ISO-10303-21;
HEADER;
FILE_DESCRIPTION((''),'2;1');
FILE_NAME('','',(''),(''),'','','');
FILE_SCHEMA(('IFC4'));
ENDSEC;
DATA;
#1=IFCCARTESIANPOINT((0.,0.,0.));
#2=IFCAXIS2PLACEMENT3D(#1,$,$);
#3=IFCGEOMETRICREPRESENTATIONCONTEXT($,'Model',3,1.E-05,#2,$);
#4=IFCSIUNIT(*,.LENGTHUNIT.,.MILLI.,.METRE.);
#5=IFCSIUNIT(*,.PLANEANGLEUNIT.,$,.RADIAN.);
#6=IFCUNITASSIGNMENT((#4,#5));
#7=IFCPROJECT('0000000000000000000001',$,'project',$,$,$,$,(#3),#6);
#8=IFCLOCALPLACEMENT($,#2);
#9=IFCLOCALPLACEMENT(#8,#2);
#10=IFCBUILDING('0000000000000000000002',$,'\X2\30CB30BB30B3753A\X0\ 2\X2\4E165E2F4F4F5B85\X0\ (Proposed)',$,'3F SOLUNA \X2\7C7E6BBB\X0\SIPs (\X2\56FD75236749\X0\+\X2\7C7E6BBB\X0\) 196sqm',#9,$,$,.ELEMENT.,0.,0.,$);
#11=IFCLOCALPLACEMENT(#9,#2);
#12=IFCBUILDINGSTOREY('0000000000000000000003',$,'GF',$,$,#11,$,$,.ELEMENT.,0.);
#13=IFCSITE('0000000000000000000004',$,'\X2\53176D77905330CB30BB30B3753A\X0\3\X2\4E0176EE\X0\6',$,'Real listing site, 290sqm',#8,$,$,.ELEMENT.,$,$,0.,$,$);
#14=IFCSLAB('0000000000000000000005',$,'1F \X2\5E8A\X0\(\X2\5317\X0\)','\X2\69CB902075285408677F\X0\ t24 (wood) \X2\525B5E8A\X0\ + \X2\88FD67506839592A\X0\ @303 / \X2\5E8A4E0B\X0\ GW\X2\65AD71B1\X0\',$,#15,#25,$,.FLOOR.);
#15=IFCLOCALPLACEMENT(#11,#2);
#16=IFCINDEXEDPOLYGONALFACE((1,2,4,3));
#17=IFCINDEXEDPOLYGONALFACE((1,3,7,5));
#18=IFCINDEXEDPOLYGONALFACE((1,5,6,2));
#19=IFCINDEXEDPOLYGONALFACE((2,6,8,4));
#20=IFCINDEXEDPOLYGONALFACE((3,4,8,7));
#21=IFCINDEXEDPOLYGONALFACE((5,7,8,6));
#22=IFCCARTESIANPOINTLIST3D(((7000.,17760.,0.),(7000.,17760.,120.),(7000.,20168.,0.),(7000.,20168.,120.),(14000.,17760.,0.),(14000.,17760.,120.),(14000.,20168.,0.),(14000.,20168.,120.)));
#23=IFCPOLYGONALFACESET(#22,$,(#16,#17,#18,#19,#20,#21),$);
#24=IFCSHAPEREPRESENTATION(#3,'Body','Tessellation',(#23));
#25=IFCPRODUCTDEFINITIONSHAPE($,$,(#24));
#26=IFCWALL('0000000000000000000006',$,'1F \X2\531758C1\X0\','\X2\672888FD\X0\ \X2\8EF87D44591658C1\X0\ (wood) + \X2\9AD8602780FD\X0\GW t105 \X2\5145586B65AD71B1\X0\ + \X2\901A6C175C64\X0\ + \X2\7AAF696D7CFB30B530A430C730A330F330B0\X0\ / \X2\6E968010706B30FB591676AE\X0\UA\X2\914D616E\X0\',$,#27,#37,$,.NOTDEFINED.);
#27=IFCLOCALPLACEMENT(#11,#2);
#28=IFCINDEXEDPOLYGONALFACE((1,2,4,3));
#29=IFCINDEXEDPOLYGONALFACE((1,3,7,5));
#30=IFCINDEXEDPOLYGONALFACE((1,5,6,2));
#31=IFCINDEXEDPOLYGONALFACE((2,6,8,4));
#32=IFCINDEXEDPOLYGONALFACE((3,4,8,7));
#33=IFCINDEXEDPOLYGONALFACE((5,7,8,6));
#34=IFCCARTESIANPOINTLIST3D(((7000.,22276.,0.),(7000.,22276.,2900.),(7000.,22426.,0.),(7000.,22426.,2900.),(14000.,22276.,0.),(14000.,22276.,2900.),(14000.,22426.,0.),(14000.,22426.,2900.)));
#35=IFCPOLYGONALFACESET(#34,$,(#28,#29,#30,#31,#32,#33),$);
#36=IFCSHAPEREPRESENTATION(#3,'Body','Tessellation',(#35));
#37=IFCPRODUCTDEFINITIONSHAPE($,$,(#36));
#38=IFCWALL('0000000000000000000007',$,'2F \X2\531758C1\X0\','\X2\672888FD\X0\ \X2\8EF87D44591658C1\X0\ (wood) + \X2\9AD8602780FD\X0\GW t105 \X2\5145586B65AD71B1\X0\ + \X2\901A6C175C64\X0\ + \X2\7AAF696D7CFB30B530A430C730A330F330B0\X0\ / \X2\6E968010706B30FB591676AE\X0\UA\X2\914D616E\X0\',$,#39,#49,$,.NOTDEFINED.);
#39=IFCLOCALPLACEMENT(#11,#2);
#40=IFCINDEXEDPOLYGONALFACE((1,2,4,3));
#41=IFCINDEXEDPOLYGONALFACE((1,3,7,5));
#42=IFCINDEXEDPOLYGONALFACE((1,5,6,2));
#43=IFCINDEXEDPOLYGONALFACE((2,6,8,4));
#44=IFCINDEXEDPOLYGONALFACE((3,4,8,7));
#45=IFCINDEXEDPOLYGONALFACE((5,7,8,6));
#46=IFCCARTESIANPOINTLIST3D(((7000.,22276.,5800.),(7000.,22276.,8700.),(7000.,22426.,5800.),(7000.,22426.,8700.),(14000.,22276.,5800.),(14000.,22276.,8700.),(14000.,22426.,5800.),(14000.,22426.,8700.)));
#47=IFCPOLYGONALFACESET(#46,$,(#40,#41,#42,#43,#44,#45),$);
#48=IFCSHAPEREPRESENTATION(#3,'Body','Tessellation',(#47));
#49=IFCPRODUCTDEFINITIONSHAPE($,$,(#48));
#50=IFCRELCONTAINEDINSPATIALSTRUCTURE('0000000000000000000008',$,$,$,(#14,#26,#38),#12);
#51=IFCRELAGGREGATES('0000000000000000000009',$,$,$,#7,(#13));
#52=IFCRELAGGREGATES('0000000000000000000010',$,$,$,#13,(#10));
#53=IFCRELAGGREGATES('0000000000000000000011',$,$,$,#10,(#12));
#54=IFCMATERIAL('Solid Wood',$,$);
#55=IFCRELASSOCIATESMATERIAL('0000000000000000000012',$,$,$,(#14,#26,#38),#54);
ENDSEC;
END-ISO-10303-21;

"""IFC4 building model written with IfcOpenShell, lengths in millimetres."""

from ifc_helpers import new_model, si_unit, frame, frame_2d, origin, place, context, project, spatial, rectangle, extrude, material, element, save


model = new_model("IFC4")

# Units and contexts
model_context = context("Model", 3, precision=1e-05, world=origin())
ifc_project = project(units=[si_unit("LENGTHUNIT", "METRE", prefix="MILLI"), si_unit("PLANEANGLEUNIT", "RADIAN")], contexts=[model_context])

# Site, building, storey
site_placement = place(None, origin())
site = spatial("IfcSite", under=ifc_project, at=site_placement, Name="北海道ニセコ町3丁目6", ObjectType="Real listing site, 290sqm", CompositionType="ELEMENT", RefElevation=0.0)
building_placement = place(site_placement, origin())
building = spatial("IfcBuilding", under=site, at=building_placement, Name="ニセコ町 2世帯住宅 (Proposed)", ObjectType="3F SOLUNA 籾殻SIPs (国産杉+籾殻) 196sqm", CompositionType="ELEMENT", ElevationOfRefHeight=0.0, ElevationOfTerrain=0.0)
storey_placement = place(building_placement, origin())
storey = spatial("IfcBuildingStorey", under=building, at=storey_placement, Name="GF", CompositionType="ELEMENT", Elevation=0.0)

# Slab
ifc_material_1 = material(Name="Solid Wood")
slab_1_placement = place(storey_placement, frame((3500.0, 8880.0, 0.0)))
element("IfcSlab", 1, at=slab_1_placement, inside=storey, material=ifc_material_1, Name="1F 床(北)", Description="構造用合板 t24 (wood) 剛床 + 製材根太 @303 / 床下 GW断熱", PredefinedType="FLOOR", context=model_context, shape_type="SweptSolid", body=[
    extrude(rectangle(XDim=7000.0, YDim=2408.0, at=frame_2d((3500.0, 1204.0))), frame((3500.0, 8880.0, 0.0)), (0.0, 0.0, 1.0), 120.0),
])

# Wall
wall_1_placement = place(storey_placement, frame((3500.0, 11138.0, 0.0)))
element("IfcWall", 2, at=wall_1_placement, inside=storey, material=ifc_material_1, Name="1F 北壁", Description="木製 軸組外壁 (wood) + 高性能GW t105 充填断熱 + 通気層 + 窯業系サイディング / 準耐火・外皮UA配慮", PredefinedType="NOTDEFINED", context=model_context, shape_type="SweptSolid", body=[
    extrude(rectangle(XDim=7000.0, YDim=150.0, at=frame_2d((3500.0, 75.0))), frame((3500.0, 11138.0, 0.0)), (0.0, 0.0, 1.0), 2900.0),
])

# Wall
wall_2_placement = place(storey_placement, frame((3500.0, 11138.0, 2900.0)))
element("IfcWall", 3, at=wall_2_placement, inside=storey, material=ifc_material_1, Name="2F 北壁", Description="木製 軸組外壁 (wood) + 高性能GW t105 充填断熱 + 通気層 + 窯業系サイディング / 準耐火・外皮UA配慮", PredefinedType="NOTDEFINED", context=model_context, shape_type="SweptSolid", body=[
    extrude(rectangle(XDim=7000.0, YDim=150.0, at=frame_2d((3500.0, 75.0))), frame((3500.0, 11138.0, 2900.0)), (0.0, 0.0, 1.0), 2900.0),
])

save(model, "model.ifc")
